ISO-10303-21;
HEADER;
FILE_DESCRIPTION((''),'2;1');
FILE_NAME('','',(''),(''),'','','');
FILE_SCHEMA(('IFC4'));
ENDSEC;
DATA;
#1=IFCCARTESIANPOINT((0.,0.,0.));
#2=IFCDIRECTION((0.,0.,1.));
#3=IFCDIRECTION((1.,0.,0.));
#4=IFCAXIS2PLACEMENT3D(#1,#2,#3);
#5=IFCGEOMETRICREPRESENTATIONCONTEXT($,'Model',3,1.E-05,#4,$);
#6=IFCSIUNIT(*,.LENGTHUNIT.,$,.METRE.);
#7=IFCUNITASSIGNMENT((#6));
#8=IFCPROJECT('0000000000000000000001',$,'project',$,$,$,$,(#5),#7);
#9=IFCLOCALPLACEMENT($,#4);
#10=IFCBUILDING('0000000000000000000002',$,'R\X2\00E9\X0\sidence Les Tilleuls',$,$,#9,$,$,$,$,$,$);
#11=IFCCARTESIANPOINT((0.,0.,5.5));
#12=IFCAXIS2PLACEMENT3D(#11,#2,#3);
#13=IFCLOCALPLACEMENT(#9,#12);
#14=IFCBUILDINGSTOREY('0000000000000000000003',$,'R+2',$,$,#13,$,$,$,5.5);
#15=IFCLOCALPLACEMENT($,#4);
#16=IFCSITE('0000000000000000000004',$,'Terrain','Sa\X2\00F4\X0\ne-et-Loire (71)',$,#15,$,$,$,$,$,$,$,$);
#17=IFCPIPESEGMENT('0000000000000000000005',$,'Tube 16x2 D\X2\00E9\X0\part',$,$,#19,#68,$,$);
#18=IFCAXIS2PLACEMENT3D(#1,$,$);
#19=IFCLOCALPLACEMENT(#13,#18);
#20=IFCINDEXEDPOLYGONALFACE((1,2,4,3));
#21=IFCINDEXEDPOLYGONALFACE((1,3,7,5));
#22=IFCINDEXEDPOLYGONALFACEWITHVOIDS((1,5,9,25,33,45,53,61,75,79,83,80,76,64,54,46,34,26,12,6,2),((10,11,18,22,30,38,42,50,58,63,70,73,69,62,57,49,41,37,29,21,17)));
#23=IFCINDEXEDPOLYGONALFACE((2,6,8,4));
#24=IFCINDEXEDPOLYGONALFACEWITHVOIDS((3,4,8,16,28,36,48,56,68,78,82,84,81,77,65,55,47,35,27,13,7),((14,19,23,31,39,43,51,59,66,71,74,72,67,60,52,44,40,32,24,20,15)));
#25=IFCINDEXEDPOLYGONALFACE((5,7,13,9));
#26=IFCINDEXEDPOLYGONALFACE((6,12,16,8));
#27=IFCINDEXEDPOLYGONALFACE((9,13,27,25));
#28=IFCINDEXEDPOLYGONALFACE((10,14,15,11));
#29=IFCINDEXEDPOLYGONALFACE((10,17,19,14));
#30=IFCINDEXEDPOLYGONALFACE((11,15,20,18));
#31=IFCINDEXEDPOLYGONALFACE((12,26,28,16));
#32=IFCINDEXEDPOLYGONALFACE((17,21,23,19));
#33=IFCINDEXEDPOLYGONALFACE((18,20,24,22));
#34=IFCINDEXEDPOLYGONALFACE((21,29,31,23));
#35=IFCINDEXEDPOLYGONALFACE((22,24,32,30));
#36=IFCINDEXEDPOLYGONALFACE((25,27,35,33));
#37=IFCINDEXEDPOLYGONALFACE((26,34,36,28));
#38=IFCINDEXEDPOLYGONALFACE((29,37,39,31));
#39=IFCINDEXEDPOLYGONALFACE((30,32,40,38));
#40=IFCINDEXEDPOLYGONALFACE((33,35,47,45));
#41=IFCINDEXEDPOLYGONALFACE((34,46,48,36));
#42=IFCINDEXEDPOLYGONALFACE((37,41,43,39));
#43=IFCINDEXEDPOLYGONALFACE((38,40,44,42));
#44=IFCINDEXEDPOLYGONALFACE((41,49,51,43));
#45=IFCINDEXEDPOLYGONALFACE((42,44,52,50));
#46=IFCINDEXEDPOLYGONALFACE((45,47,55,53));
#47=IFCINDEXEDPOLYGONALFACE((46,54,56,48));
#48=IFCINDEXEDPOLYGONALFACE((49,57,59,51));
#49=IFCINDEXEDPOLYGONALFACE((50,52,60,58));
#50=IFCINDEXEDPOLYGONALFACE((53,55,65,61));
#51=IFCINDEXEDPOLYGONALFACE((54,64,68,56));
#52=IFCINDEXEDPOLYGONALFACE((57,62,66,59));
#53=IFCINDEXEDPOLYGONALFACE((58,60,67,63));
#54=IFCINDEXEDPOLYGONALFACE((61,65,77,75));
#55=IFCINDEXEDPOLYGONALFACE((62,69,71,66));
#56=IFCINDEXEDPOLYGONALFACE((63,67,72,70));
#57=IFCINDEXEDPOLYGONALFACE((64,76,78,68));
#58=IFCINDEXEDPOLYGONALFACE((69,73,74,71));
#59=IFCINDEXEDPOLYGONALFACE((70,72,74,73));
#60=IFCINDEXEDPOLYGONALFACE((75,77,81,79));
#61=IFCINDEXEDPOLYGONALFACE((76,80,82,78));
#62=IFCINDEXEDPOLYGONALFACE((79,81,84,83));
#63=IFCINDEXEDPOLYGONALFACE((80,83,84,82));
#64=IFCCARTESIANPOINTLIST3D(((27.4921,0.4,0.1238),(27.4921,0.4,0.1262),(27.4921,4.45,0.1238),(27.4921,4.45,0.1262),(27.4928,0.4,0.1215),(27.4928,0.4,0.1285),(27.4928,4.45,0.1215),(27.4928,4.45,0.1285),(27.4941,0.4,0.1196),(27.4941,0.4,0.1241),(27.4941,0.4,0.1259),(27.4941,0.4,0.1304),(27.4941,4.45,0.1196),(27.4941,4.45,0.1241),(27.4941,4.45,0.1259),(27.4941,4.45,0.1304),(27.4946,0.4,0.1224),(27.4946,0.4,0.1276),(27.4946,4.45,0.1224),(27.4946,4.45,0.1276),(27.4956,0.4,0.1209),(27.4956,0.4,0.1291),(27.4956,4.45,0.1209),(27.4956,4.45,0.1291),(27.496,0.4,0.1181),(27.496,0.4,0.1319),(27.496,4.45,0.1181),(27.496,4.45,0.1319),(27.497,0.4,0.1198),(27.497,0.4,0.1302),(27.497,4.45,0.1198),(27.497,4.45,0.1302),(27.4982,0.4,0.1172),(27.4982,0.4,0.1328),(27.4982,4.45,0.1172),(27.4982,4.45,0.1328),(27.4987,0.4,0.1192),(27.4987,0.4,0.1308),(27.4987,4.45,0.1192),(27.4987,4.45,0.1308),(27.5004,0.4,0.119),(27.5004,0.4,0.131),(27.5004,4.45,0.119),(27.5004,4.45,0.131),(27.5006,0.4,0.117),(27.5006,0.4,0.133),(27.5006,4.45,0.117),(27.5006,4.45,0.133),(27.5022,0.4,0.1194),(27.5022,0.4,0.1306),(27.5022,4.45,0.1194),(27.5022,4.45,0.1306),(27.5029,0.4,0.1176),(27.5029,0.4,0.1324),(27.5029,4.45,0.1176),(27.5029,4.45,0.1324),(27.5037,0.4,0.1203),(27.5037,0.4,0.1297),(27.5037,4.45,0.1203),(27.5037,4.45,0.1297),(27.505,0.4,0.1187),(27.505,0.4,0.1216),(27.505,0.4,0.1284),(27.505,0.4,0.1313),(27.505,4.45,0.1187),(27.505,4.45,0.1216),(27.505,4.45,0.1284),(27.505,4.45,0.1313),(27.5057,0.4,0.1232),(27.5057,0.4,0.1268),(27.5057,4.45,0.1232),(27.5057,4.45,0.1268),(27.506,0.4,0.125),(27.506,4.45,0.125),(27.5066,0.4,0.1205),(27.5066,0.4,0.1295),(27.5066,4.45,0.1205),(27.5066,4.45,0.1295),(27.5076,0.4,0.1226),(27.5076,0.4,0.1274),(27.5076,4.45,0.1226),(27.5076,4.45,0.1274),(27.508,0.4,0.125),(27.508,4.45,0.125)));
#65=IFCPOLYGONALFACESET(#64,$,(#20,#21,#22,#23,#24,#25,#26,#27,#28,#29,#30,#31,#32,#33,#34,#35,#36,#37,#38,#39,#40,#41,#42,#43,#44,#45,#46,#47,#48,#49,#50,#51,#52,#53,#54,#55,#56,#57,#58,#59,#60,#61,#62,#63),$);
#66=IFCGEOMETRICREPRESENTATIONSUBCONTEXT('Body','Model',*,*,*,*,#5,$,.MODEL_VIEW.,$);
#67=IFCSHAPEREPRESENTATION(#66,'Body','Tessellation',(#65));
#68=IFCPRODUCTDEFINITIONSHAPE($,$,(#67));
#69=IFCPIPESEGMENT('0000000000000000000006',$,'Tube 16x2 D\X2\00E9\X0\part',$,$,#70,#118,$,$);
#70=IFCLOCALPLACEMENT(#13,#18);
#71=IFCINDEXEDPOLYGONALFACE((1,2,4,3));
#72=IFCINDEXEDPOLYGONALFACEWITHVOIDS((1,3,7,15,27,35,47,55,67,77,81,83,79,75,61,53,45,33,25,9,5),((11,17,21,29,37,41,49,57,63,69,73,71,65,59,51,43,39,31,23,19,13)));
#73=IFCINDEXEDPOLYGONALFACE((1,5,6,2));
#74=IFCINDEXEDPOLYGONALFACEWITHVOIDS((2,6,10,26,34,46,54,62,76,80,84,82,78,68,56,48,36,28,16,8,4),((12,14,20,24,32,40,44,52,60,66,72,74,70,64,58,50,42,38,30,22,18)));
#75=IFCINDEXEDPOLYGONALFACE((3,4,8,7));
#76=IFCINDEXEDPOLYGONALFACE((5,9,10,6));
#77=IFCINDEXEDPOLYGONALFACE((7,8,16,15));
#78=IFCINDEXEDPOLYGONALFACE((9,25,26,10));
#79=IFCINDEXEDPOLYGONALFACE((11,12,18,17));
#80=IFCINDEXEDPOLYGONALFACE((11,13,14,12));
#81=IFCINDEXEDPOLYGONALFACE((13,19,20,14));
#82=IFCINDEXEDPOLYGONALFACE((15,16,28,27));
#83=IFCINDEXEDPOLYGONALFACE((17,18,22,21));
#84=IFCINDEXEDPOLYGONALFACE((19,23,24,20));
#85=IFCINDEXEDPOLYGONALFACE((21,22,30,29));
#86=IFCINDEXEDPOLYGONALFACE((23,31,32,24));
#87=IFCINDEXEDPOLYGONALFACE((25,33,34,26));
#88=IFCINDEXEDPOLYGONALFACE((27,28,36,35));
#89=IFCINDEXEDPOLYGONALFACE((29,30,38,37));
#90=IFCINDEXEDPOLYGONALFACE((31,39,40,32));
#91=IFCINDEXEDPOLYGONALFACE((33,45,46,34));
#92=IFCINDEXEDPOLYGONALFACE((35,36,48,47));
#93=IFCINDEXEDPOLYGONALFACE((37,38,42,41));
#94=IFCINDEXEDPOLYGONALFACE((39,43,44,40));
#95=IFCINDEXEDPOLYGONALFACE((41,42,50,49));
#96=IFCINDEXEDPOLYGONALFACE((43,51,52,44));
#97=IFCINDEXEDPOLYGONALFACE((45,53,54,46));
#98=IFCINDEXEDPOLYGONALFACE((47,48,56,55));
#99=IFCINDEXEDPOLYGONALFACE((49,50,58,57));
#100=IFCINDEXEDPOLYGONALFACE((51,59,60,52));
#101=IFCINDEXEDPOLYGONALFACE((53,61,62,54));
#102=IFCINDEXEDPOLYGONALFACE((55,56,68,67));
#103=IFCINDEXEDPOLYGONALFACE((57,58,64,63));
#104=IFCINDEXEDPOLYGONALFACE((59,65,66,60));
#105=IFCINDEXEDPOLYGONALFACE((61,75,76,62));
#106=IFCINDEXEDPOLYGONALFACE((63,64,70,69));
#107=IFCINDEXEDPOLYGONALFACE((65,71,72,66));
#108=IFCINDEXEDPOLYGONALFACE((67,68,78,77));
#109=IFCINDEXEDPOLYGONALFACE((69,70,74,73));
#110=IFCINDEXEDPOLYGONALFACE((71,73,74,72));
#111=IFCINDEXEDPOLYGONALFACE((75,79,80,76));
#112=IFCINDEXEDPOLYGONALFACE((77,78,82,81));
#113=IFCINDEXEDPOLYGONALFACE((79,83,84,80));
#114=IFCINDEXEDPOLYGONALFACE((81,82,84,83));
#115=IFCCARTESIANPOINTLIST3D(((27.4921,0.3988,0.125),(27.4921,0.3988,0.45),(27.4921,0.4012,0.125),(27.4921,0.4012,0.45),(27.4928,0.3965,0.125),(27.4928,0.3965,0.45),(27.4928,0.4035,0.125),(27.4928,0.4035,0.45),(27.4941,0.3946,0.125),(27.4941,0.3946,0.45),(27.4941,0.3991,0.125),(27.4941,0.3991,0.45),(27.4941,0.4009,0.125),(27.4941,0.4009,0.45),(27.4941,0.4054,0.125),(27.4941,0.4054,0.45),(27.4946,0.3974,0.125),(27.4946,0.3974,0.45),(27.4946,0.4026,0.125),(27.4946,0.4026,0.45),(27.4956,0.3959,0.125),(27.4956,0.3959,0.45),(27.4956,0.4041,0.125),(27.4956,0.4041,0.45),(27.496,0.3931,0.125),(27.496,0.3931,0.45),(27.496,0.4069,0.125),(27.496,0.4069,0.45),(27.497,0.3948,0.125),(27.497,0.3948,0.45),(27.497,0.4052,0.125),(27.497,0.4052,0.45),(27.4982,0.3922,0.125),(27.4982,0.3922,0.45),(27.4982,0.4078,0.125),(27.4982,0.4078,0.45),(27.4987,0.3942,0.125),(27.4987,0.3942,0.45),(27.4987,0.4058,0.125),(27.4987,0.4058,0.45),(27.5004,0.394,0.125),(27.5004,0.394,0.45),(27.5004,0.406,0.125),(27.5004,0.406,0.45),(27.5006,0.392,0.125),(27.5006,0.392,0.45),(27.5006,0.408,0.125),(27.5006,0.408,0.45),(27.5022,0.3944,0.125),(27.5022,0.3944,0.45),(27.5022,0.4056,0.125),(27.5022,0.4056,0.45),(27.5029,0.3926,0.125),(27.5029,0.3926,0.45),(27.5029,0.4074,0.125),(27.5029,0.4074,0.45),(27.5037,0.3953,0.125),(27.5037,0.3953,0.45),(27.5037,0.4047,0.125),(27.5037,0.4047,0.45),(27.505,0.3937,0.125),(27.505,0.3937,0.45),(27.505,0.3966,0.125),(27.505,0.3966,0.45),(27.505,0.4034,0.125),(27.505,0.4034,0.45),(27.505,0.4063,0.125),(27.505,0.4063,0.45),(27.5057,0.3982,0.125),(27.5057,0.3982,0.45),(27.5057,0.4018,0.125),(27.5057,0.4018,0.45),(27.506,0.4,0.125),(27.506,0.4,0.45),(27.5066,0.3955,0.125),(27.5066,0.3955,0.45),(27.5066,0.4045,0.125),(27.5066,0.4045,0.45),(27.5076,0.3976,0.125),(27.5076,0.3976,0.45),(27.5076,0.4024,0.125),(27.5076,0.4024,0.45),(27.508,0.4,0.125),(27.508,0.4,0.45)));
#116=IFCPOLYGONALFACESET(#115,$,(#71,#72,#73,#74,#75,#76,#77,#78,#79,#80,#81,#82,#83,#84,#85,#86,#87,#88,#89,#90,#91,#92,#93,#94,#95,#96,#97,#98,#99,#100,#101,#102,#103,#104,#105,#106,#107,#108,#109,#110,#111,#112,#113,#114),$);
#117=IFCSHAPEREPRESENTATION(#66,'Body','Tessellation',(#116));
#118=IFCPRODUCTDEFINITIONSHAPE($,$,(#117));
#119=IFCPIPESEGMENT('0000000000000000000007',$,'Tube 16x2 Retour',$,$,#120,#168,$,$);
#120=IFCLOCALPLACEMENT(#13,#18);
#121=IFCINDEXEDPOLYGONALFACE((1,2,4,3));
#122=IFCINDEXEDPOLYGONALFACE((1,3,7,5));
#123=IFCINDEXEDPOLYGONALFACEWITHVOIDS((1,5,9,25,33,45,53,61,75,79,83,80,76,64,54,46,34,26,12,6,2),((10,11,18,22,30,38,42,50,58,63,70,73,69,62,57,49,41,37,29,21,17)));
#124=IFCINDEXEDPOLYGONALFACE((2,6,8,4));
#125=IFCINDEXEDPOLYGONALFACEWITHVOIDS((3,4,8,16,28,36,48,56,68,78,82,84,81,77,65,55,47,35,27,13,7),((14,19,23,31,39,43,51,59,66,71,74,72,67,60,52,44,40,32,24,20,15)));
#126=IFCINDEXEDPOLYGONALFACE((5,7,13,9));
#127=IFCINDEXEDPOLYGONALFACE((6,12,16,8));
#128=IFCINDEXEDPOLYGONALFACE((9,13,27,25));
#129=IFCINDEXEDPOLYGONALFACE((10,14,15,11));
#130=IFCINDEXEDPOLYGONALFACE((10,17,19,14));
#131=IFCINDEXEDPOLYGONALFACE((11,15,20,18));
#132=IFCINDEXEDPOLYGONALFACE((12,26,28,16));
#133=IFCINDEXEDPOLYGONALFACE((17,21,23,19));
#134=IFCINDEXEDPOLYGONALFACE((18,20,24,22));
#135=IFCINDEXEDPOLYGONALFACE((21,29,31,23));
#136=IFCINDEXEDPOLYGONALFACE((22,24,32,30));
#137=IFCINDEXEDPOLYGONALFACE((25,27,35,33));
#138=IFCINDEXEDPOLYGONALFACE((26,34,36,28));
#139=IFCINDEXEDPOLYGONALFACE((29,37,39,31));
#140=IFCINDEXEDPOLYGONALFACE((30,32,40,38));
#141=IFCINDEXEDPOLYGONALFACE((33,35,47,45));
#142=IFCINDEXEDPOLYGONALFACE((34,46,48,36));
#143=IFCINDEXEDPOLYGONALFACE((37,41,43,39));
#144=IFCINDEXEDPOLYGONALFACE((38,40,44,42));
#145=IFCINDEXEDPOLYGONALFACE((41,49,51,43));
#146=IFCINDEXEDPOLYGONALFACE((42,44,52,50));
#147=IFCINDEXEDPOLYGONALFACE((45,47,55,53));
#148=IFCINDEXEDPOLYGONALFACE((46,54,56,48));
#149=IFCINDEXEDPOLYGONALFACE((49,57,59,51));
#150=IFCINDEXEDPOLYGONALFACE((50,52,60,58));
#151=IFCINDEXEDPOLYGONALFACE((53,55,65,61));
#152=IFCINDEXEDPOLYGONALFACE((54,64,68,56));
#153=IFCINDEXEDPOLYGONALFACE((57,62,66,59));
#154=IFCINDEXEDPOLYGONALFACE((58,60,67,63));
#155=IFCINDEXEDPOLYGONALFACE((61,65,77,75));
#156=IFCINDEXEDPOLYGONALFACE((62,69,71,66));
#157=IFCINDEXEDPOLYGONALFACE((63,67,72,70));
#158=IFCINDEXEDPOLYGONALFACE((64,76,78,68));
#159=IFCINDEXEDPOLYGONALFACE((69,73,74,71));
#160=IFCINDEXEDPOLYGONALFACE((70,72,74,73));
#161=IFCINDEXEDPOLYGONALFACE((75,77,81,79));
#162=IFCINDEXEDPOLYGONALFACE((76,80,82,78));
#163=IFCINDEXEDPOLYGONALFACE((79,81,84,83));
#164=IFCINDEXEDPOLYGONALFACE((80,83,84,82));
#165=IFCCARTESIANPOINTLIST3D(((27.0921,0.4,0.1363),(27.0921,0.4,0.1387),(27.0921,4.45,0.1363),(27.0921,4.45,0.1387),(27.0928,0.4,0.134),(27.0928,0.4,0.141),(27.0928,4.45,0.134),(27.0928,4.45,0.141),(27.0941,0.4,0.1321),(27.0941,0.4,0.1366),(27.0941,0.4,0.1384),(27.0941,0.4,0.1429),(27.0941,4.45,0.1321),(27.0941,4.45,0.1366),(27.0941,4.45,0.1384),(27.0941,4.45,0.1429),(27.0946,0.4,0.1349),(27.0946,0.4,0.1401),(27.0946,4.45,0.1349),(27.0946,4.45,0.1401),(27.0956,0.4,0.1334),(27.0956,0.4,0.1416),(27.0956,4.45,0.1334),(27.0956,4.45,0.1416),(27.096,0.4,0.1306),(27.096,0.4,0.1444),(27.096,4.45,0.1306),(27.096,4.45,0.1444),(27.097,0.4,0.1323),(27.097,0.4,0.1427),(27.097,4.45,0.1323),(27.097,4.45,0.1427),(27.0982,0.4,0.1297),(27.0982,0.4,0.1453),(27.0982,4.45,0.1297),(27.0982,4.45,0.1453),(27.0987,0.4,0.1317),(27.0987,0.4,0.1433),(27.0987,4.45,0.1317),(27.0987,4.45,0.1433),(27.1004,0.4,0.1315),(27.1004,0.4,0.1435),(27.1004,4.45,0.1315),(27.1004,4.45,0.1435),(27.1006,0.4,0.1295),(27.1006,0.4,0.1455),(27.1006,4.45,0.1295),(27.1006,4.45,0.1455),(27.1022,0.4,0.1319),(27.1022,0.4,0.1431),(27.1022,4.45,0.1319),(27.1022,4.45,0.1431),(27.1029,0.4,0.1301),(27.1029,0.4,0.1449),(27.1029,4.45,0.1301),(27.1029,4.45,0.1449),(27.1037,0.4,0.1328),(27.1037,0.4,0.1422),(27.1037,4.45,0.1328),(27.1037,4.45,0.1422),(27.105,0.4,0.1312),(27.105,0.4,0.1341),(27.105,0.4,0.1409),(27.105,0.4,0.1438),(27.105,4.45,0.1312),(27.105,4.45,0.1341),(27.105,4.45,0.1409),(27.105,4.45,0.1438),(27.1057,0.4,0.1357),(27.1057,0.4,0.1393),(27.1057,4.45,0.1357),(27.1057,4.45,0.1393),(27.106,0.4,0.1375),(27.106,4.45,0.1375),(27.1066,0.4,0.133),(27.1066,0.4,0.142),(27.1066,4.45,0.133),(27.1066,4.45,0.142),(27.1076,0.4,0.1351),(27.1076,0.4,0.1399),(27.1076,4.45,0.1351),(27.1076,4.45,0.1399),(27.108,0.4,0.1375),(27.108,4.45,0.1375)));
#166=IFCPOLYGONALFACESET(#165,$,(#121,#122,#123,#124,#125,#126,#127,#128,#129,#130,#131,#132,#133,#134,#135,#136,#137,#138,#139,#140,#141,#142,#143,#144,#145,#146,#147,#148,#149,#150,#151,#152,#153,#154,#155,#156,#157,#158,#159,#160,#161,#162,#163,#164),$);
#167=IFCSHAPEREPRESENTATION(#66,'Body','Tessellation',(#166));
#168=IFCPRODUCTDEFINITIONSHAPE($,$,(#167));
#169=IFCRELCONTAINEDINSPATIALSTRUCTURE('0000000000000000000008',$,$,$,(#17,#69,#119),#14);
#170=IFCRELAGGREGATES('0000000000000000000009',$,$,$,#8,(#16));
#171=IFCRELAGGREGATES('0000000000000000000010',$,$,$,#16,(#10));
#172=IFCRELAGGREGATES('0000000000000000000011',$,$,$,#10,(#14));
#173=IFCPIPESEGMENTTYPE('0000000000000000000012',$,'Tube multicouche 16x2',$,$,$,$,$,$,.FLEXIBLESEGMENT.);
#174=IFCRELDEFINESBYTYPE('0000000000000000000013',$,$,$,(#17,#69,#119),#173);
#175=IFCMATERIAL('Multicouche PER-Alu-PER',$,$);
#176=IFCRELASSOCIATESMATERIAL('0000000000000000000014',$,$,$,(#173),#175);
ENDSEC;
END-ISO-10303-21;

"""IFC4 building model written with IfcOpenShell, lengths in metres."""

from ifc_helpers import new_model, si_unit, frame, origin_with_axes, place, context, subcontext, project, spatial, hollow_circle, extrude, material, type_object, element, save


model = new_model("IFC4")

# Units and contexts
model_context = context("Model", 3, precision=1e-05, world=origin_with_axes())
body_context = subcontext(model_context, "Body", "Model", "MODEL_VIEW")
ifc_project = project(units=[si_unit("LENGTHUNIT", "METRE")], contexts=[model_context])

# Site, building, storey
site_placement = place(None, origin_with_axes())
site = spatial("IfcSite", under=ifc_project, at=site_placement, Name="Terrain", Description="Saône-et-Loire (71)")
building_placement = place(None, origin_with_axes())
building = spatial("IfcBuilding", under=site, at=building_placement, Name="Résidence Les Tilleuls")
storey_placement = place(building_placement, frame((0.0, 0.0, 5.5), z_axis=(0.0, 0.0, 1.0), x_axis=(1.0, 0.0, 0.0)))
storey = spatial("IfcBuildingStorey", under=building, at=storey_placement, Name="R+2", Elevation=5.5)

# Pipe segments
ifc_material_1 = material(Name="Multicouche PER-Alu-PER")
pipe_segment_type_1 = type_object("IfcPipeSegmentType", Name="Tube multicouche 16x2", PredefinedType="FLEXIBLESEGMENT", material=ifc_material_1)
pipe_segment_1_placement = place(storey_placement, frame((27.5, 4.45, 0.125), z_axis=(0.0, -1.0, 0.0), x_axis=(1.0, 0.0, 0.0)))
element("IfcPipeSegment", 1, at=pipe_segment_1_placement, inside=storey, type_object=pipe_segment_type_1, Name="Tube 16x2 Départ", context=body_context, shape_type="SweptSolid", body=[
    extrude(hollow_circle(Radius=0.008, WallThickness=0.002), origin_with_axes(), (0.0, 0.0, 1.0), 4.05),
])
pipe_segment_2_placement = place(storey_placement, frame((27.5, 0.4, 0.125), z_axis=(0.0, 0.0, 1.0), x_axis=(1.0, 0.0, 0.0)))
element("IfcPipeSegment", 2, at=pipe_segment_2_placement, inside=storey, type_object=pipe_segment_type_1, Name="Tube 16x2 Départ", context=body_context, shape_type="SweptSolid", body=[
    extrude(hollow_circle(Radius=0.008, WallThickness=0.002), origin_with_axes(), (0.0, 0.0, 1.0), 0.325),
])
pipe_segment_3_placement = place(storey_placement, frame((27.1, 4.45, 0.1375), z_axis=(0.0, -1.0, 0.0), x_axis=(1.0, 0.0, 0.0)))
element("IfcPipeSegment", 3, at=pipe_segment_3_placement, inside=storey, type_object=pipe_segment_type_1, Name="Tube 16x2 Retour", context=body_context, shape_type="SweptSolid", body=[
    extrude(hollow_circle(Radius=0.008, WallThickness=0.002), origin_with_axes(), (0.0, 0.0, 1.0), 4.05),
])

save(model, "model.ifc")
